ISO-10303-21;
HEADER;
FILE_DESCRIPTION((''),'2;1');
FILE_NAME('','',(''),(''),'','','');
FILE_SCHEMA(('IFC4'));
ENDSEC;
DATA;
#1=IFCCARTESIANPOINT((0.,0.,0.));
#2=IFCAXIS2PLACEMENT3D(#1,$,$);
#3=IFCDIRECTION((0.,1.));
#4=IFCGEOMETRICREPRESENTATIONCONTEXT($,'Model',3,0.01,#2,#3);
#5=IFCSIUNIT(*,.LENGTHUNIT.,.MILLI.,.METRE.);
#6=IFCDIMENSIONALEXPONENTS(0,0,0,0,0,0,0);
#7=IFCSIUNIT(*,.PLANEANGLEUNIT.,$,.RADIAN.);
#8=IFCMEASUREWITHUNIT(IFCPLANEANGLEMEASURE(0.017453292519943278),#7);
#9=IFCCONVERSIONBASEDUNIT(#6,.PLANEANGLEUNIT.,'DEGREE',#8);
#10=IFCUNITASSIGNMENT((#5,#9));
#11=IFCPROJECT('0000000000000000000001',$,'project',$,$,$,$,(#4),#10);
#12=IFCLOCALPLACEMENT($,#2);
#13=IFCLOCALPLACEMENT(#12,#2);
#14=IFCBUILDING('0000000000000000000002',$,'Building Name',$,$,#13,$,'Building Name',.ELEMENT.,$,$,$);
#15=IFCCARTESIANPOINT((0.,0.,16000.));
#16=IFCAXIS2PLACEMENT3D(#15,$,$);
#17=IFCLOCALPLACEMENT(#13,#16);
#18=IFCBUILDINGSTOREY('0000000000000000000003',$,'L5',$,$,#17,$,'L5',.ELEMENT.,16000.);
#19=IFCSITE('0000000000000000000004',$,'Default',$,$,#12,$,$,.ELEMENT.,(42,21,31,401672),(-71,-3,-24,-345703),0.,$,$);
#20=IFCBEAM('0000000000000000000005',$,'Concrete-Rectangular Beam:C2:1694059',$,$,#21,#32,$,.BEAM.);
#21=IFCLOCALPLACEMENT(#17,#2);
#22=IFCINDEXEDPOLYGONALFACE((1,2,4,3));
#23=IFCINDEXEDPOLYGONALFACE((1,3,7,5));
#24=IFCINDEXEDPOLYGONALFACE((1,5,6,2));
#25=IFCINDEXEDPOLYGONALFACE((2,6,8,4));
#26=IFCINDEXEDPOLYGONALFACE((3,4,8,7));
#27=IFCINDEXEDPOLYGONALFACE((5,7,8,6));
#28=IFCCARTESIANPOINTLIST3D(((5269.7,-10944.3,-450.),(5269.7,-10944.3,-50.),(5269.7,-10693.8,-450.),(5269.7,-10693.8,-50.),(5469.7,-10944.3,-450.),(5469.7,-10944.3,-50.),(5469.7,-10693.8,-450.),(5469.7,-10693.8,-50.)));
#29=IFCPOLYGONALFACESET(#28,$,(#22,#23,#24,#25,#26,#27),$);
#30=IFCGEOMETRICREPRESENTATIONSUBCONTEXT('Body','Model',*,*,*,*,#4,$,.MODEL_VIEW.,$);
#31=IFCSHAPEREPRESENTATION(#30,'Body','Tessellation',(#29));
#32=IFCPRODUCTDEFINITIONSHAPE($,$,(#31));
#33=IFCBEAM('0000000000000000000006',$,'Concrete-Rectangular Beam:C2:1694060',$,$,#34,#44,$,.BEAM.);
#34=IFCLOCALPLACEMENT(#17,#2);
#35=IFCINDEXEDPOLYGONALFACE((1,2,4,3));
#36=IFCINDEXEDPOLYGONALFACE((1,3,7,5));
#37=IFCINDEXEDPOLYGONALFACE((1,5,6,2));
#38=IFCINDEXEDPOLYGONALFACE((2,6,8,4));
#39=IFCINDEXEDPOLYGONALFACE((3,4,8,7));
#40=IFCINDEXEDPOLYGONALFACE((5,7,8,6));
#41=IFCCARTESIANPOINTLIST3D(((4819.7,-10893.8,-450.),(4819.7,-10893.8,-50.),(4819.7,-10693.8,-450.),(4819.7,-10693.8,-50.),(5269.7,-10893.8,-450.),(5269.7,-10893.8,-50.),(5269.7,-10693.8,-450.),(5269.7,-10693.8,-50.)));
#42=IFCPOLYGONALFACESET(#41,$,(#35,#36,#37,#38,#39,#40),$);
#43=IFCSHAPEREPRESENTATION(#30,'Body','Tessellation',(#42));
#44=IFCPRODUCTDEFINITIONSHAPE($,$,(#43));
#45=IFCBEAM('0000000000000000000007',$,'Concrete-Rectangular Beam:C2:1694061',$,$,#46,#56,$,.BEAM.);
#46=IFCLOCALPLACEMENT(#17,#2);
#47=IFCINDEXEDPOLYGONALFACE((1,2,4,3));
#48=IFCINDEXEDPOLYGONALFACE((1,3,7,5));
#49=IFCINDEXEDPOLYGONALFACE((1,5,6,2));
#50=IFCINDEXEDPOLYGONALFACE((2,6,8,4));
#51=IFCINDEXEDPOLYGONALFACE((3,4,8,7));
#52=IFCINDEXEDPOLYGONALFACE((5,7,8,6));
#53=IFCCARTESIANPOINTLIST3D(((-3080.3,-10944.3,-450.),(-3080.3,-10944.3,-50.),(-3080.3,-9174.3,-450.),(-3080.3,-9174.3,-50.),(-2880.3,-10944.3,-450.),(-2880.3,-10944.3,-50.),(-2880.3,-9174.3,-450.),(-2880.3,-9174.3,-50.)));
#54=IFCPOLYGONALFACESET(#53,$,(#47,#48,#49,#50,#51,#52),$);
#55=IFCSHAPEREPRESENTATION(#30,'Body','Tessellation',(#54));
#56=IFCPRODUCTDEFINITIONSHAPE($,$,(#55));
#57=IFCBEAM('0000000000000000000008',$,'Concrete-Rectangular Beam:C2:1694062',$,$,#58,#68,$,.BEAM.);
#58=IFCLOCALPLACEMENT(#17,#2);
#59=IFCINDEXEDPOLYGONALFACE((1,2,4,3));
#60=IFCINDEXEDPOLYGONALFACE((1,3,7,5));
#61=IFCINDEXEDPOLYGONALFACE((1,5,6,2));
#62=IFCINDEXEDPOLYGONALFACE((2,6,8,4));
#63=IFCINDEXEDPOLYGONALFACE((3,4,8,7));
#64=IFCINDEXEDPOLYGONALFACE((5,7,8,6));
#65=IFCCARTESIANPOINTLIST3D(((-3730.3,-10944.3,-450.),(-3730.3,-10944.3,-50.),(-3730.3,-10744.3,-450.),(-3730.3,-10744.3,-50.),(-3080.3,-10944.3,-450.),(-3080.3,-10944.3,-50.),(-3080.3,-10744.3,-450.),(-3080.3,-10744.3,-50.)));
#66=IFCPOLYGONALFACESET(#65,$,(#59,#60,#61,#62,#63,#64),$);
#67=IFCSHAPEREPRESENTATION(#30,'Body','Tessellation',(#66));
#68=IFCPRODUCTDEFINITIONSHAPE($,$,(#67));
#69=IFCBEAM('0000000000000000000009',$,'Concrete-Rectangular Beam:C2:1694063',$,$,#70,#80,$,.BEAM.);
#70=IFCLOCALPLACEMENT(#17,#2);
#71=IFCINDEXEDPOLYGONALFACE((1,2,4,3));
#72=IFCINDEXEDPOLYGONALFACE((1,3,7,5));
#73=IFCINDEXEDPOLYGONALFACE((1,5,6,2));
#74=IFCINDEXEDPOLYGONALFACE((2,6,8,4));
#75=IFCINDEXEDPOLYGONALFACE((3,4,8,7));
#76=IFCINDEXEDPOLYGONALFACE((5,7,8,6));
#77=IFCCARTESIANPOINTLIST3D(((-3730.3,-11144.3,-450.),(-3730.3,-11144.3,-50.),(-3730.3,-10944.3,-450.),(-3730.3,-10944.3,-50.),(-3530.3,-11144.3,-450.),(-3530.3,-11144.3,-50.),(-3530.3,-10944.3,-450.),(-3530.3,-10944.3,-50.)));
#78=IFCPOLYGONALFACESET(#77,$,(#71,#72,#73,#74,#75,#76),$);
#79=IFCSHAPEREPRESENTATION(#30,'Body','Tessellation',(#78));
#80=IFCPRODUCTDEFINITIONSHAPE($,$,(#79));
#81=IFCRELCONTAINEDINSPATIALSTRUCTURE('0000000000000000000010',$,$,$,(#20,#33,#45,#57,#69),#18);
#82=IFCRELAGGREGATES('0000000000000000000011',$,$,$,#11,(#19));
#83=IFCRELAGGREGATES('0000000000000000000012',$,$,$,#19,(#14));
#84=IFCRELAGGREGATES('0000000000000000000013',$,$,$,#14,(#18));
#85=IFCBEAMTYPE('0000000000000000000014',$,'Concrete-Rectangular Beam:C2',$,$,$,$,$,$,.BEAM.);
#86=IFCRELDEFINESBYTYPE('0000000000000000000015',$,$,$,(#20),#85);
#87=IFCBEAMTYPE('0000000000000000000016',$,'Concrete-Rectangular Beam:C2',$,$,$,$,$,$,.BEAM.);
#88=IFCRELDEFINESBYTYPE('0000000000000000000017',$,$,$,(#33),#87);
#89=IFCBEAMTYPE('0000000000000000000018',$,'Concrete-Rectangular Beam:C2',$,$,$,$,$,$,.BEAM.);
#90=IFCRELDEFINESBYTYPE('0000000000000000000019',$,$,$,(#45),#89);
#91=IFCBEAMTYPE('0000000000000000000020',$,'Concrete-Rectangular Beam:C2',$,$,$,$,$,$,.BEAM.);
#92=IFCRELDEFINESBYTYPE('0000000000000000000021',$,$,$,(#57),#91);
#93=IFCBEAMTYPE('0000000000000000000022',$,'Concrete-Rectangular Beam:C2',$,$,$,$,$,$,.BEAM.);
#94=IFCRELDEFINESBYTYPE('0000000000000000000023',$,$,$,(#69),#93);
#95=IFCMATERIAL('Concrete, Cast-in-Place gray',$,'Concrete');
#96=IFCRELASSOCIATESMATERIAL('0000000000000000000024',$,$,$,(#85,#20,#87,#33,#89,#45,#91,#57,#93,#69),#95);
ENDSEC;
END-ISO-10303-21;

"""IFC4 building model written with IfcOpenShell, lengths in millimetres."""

from ifc_helpers import new_model, entity, si_unit, converted_unit, direction, frame, origin, place, context, subcontext, project, spatial, indexed_curve, outline, extrude, source, transform, mapped, material, type_object, type_shapes, element, save


model = new_model("IFC4")

# Units and contexts
model_context = context("Model", 3, precision=0.01, world=origin(), true_north=direction((0.0, 1.0)))
body_context = subcontext(model_context, "Body", "Model", "MODEL_VIEW")
ifc_project = project(units=[si_unit("LENGTHUNIT", "METRE", prefix="MILLI"), converted_unit("PLANEANGLEUNIT", "DEGREE", entity("IfcPlaneAngleMeasure", 0.017453292519943278), si_unit("PLANEANGLEUNIT", "RADIAN"), dimensions=[0, 0, 0, 0, 0, 0, 0])], contexts=[model_context])

# Site, building, storey
site_placement = place(None, origin())
site = spatial("IfcSite", under=ifc_project, at=site_placement, Name="Default", CompositionType="ELEMENT", RefLatitude=(42, 21, 31, 401672), RefLongitude=(-71, -3, -24, -345703), RefElevation=0.0)
building_placement = place(site_placement, origin())
building = spatial("IfcBuilding", under=site, at=building_placement, Name="Building Name", LongName="Building Name", CompositionType="ELEMENT")
storey_placement = place(building_placement, frame((0.0, 0.0, 16000.0)))
storey = spatial("IfcBuildingStorey", under=building, at=storey_placement, Name="L5", LongName="L5", CompositionType="ELEMENT", Elevation=16000.0)

# Beams
ifc_material = material(Name="Concrete, Cast-in-Place gray", Category="Concrete")
beam_type_1 = type_object("IfcBeamType", Name="Concrete-Rectangular Beam:C2", PredefinedType="BEAM", material=ifc_material)
shared_shape_1 = source(origin(), body_context, "Body", "SweptSolid", [
    extrude(outline(indexed_curve([(-100.0, -200.0), (100.0, -200.0), (100.0, 200.0), (-100.0, 200.0), (-100.0, -200.0)], self_intersect=False)), frame((5369.7, -10944.3, 15750.0), z_axis=(0.0, 1.0, 0.0), x_axis=(-1.0, 0.0, 0.0)), (0.0, 0.0, 1.0), 250.5),
])
type_shapes(beam_type_1, [shared_shape_1])
beam_1_placement = place(storey_placement, frame((0.0, 0.0, -16000.0)))
element("IfcBeam", 1, at=beam_1_placement, inside=storey, type_object=beam_type_1, material=ifc_material, Name="Concrete-Rectangular Beam:C2:1694059", PredefinedType="BEAM", context=body_context, shape_type="MappedRepresentation", body=[
    mapped(shared_shape_1, transform((0.0, 0.0, 0.0), scale=1.0)),
])
beam_type_2 = type_object("IfcBeamType", Name="Concrete-Rectangular Beam:C2", PredefinedType="BEAM", material=ifc_material)
shared_shape_2 = source(origin(), body_context, "Body", "SweptSolid", [
    extrude(outline(indexed_curve([(-200.0, -100.0), (200.0, -100.0), (200.0, 100.0), (-200.0, 100.0), (-200.0, -100.0)], self_intersect=False)), frame((5269.7, -10793.8, 15750.0), z_axis=(-1.0, 0.0, 0.0), x_axis=(0.0, 0.0, -1.0)), (0.0, 0.0, 1.0), 450.0),
])
type_shapes(beam_type_2, [shared_shape_2])
beam_2_placement = place(storey_placement, frame((0.0, 0.0, -16000.0)))
element("IfcBeam", 2, at=beam_2_placement, inside=storey, type_object=beam_type_2, material=ifc_material, Name="Concrete-Rectangular Beam:C2:1694060", PredefinedType="BEAM", context=body_context, shape_type="MappedRepresentation", body=[
    mapped(shared_shape_2, transform((0.0, 0.0, 0.0), scale=1.0)),
])
beam_type_3 = type_object("IfcBeamType", Name="Concrete-Rectangular Beam:C2", PredefinedType="BEAM", material=ifc_material)
shared_shape_3 = source(origin(), body_context, "Body", "SweptSolid", [
    extrude(outline(indexed_curve([(-100.0, -200.0), (100.0, -200.0), (100.0, 200.0), (-100.0, 200.0), (-100.0, -200.0)], self_intersect=False)), frame((-2980.3, -9174.3, 15750.0), z_axis=(0.0, -1.0, 0.0), x_axis=(-1.0, 0.0, 0.0)), (0.0, 0.0, 1.0), 1770.0),
])
type_shapes(beam_type_3, [shared_shape_3])
beam_3_placement = place(storey_placement, frame((0.0, 0.0, -16000.0)))
element("IfcBeam", 3, at=beam_3_placement, inside=storey, type_object=beam_type_3, material=ifc_material, Name="Concrete-Rectangular Beam:C2:1694061", PredefinedType="BEAM", context=body_context, shape_type="MappedRepresentation", body=[
    mapped(shared_shape_3, transform((0.0, 0.0, 0.0), scale=1.0)),
])
beam_type_4 = type_object("IfcBeamType", Name="Concrete-Rectangular Beam:C2", PredefinedType="BEAM", material=ifc_material)
shared_shape_4 = source(origin(), body_context, "Body", "SweptSolid", [
    extrude(outline(indexed_curve([(-200.0, -100.0), (200.0, -100.0), (200.0, 100.0), (-200.0, 100.0), (-200.0, -100.0)], self_intersect=False)), frame((-3080.3, -10844.3, 15750.0), z_axis=(-1.0, 0.0, 0.0), x_axis=(0.0, 0.0, -1.0)), (0.0, 0.0, 1.0), 650.0),
])
type_shapes(beam_type_4, [shared_shape_4])
beam_4_placement = place(storey_placement, frame((0.0, 0.0, -16000.0)))
element("IfcBeam", 4, at=beam_4_placement, inside=storey, type_object=beam_type_4, material=ifc_material, Name="Concrete-Rectangular Beam:C2:1694062", PredefinedType="BEAM", context=body_context, shape_type="MappedRepresentation", body=[
    mapped(shared_shape_4, transform((0.0, 0.0, 0.0), scale=1.0)),
])
beam_type_5 = type_object("IfcBeamType", Name="Concrete-Rectangular Beam:C2", PredefinedType="BEAM", material=ifc_material)
shared_shape_5 = source(origin(), body_context, "Body", "SweptSolid", [
    extrude(outline(indexed_curve([(-100.0, -200.0), (100.0, -200.0), (100.0, 200.0), (-100.0, 200.0), (-100.0, -200.0)], self_intersect=False)), frame((-3630.3, -10944.3, 15750.0), z_axis=(0.0, -1.0, 0.0), x_axis=(-1.0, 0.0, 0.0)), (0.0, 0.0, 1.0), 200.0),
])
type_shapes(beam_type_5, [shared_shape_5])
beam_5_placement = place(storey_placement, frame((0.0, 0.0, -16000.0)))
element("IfcBeam", 5, at=beam_5_placement, inside=storey, type_object=beam_type_5, material=ifc_material, Name="Concrete-Rectangular Beam:C2:1694063", PredefinedType="BEAM", context=body_context, shape_type="MappedRepresentation", body=[
    mapped(shared_shape_5, transform((0.0, 0.0, 0.0), scale=1.0)),
])

save(model, "model.ifc")
